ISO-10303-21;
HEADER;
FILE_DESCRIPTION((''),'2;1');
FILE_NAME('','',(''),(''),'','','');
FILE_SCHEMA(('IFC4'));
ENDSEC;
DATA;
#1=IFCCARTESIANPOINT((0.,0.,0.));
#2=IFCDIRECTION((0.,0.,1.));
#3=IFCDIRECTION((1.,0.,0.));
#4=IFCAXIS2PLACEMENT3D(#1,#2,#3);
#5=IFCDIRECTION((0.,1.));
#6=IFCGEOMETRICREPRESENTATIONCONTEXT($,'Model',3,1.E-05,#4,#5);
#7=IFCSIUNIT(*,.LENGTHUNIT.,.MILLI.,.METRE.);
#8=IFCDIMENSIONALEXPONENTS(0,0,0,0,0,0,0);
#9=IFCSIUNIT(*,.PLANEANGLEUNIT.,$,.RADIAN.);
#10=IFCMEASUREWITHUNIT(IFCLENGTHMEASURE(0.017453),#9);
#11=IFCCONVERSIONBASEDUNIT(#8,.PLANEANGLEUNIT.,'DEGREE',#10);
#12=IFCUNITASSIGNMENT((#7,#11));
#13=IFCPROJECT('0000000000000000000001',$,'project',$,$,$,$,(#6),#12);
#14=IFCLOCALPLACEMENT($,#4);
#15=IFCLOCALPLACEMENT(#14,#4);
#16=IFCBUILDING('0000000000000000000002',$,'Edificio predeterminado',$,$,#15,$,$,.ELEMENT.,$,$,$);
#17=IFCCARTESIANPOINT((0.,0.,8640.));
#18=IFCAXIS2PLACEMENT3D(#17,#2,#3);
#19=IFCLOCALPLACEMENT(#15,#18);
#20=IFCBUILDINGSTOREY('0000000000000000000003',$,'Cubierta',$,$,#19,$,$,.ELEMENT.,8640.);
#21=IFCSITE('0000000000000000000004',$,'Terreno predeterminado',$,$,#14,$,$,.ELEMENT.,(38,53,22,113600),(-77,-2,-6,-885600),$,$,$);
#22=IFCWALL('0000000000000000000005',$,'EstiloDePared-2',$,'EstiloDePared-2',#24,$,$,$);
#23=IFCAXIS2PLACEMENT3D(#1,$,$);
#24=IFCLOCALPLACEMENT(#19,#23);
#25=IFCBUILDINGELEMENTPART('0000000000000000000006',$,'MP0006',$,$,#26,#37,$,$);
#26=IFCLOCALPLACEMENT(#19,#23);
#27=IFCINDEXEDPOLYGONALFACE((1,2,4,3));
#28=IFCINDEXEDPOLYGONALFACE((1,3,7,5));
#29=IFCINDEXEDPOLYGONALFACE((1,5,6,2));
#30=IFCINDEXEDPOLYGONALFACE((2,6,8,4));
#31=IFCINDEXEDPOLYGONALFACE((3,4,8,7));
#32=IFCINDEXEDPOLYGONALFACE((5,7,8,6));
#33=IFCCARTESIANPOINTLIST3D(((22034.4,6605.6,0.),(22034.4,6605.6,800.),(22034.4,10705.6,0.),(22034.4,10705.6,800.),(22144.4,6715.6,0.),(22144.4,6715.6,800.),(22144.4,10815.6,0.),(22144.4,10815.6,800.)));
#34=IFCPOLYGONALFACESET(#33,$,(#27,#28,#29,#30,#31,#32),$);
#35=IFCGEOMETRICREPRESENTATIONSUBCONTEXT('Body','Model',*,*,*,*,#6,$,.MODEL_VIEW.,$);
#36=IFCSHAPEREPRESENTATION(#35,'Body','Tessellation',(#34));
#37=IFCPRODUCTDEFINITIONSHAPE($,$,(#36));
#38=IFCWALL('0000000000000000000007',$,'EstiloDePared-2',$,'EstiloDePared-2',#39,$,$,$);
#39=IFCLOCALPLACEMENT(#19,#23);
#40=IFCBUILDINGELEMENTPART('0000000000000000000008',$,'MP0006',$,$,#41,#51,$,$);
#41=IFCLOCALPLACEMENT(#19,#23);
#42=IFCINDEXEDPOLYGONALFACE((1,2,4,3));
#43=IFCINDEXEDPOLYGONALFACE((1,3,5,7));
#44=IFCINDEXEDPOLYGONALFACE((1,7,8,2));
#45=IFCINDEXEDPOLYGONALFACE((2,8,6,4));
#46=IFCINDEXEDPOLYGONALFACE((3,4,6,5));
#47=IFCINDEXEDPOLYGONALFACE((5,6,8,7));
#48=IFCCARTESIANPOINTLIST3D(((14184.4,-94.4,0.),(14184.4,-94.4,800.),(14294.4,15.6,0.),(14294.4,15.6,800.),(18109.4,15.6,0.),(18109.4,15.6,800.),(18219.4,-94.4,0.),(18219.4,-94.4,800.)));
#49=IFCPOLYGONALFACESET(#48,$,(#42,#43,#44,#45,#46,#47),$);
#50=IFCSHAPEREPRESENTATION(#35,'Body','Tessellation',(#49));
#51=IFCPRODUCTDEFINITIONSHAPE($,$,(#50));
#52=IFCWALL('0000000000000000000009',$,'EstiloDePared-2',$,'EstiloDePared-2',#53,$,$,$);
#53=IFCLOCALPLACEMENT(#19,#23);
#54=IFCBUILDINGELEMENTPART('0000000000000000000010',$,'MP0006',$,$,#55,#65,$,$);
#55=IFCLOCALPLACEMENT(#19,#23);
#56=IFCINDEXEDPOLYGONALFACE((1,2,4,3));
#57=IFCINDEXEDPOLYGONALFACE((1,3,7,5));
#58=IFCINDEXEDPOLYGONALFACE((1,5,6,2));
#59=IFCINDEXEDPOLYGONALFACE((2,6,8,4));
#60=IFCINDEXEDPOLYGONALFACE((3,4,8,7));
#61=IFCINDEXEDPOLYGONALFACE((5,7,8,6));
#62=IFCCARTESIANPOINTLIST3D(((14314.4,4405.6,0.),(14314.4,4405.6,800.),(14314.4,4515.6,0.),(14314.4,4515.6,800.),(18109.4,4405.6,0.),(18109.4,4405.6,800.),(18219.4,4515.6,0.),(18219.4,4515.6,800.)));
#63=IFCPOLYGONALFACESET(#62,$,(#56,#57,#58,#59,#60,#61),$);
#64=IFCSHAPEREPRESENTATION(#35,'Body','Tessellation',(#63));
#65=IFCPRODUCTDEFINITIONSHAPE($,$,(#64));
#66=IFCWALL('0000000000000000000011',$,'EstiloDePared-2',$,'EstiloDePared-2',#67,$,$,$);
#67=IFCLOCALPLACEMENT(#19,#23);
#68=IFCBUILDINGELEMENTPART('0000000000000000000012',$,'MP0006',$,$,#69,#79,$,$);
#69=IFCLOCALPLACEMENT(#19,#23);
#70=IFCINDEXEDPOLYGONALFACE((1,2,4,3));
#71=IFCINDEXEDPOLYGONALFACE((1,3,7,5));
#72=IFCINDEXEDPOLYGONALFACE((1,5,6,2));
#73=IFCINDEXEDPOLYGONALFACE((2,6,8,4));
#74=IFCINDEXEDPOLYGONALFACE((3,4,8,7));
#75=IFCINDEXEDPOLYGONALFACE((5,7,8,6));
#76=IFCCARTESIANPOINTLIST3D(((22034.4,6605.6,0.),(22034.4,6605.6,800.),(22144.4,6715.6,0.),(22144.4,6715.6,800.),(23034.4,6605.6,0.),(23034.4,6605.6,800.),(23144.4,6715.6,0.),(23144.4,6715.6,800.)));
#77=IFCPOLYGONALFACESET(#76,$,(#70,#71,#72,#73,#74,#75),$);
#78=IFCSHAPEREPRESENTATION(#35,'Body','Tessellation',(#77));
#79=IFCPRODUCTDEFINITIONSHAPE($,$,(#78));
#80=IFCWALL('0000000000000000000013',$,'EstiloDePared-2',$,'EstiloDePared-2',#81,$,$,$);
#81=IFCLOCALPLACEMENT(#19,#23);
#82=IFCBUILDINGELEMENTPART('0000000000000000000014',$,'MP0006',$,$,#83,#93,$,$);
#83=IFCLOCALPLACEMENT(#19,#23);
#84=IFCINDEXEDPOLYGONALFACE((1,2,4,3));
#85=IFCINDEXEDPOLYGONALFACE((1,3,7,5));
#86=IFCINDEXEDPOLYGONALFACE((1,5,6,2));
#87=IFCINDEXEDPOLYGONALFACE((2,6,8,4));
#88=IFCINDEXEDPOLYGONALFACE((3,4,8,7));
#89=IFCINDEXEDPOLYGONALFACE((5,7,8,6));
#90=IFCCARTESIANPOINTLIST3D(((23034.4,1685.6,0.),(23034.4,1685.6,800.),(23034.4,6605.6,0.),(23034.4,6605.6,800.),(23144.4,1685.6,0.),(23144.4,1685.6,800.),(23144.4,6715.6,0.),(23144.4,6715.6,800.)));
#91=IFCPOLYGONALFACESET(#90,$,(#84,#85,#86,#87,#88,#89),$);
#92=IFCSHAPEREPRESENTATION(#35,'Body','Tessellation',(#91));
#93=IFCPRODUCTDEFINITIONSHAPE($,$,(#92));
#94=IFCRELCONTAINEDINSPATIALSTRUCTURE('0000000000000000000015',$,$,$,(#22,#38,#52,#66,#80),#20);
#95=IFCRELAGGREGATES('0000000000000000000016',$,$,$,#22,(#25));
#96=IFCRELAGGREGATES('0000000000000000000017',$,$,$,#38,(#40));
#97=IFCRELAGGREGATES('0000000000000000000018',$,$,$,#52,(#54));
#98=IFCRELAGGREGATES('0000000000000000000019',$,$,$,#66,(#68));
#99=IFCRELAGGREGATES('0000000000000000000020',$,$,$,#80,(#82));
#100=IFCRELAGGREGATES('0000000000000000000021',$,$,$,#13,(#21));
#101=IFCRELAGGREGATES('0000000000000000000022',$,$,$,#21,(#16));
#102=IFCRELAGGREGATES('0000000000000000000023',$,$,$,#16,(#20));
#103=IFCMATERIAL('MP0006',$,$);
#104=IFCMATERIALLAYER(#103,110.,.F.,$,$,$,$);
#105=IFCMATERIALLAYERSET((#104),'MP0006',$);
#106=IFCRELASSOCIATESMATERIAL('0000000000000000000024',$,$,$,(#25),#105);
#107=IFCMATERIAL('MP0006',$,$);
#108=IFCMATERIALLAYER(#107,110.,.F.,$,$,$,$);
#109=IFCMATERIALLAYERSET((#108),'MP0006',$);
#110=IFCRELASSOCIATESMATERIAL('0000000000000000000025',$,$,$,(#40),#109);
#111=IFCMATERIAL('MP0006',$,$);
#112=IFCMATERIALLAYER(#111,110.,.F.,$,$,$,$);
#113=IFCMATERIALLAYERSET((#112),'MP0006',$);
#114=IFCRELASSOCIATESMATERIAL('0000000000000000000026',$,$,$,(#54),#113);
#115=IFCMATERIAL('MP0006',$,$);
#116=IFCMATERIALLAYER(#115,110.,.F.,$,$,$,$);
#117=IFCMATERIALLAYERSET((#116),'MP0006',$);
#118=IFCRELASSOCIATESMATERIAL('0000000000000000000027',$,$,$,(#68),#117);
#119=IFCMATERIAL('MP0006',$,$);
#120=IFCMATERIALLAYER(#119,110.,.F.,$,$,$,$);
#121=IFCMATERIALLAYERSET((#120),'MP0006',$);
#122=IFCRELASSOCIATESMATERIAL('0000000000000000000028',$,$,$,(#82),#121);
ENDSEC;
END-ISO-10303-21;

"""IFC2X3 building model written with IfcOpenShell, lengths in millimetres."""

from ifc_helpers import new_model, entity, si_unit, converted_unit, direction, frame, origin_with_axes, place, context, subcontext, project, spatial, polyline, outline, extrude, material, layer, layer_set, layer_usage, element, aggregate, save


model = new_model("IFC2X3")

# Units and contexts
model_context = context("Model", 3, precision=1e-05, world=origin_with_axes(), true_north=direction((0.0, 1.0)))
body_context = subcontext(model_context, "Body", "Model", "MODEL_VIEW")
ifc_project = project(units=[si_unit("LENGTHUNIT", "METRE", prefix="MILLI"), converted_unit("PLANEANGLEUNIT", "DEGREE", entity("IfcLengthMeasure", 0.017453), si_unit("PLANEANGLEUNIT", "RADIAN"), dimensions=[0, 0, 0, 0, 0, 0, 0])], contexts=[model_context])

# Site, building, storey
site_placement = place(None, origin_with_axes())
site = spatial("IfcSite", under=ifc_project, at=site_placement, Name="Terreno predeterminado", CompositionType="ELEMENT", RefLatitude=(38, 53, 22, 113600), RefLongitude=(-77, -2, -6, -885600))
building_placement = place(site_placement, origin_with_axes())
building = spatial("IfcBuilding", under=site, at=building_placement, Name="Edificio predeterminado", CompositionType="ELEMENT")
storey_placement = place(building_placement, frame((0.0, 0.0, 8640.0), z_axis=(0.0, 0.0, 1.0), x_axis=(1.0, 0.0, 0.0)))
storey = spatial("IfcBuildingStorey", under=building, at=storey_placement, Name="Cubierta", CompositionType="ELEMENT", Elevation=8640.0)

# Wall, building element part
wall_1_placement = place(storey_placement, frame((22089.4, 10760.6, 0.0), z_axis=(0.0, 0.0, 1.0), x_axis=(0.0, -1.0, 0.0)))
wall_1 = element("IfcWall", 1, at=wall_1_placement, inside=storey, Name="EstiloDePared-2", ObjectType="EstiloDePared-2")
ifc_material_1 = material(Name="MP0006")
ifc_layer_1 = layer(ifc_material_1, 110.0, ventilated=False)
ifc_layer_set_1 = layer_set([ifc_layer_1], Name="MP0006")
ifc_layer_usage_1 = layer_usage(ifc_layer_set_1, "AXIS2", "NEGATIVE", -55.0)
building_element_part_1_placement = place(wall_1_placement, origin_with_axes())
building_element_part_1 = element("IfcBuildingElementPart", 2, at=building_element_part_1_placement, material=ifc_layer_usage_1, Name="MP0006", context=body_context, shape_type="SweptSolid", body=[
    extrude(outline(polyline([(4045.0, 55.0), (4155.0, -55.0), (55.0, -55.0), (-55.0, 55.0), (4045.0, 55.0)])), origin_with_axes(), (0.0, 0.0, 1.0), 800.0),
])
aggregate(wall_1, [building_element_part_1])

# Walls, building element parts
wall_2_placement = place(storey_placement, frame((18164.4, -39.4, 0.0), z_axis=(0.0, 0.0, 1.0), x_axis=(-1.0, 0.0, 0.0)))
wall_2 = element("IfcWall", 3, at=wall_2_placement, inside=storey, Name="EstiloDePared-2", ObjectType="EstiloDePared-2")
ifc_material_2 = material(Name="MP0006")
ifc_layer_2 = layer(ifc_material_2, 110.0, ventilated=False)
ifc_layer_set_2 = layer_set([ifc_layer_2], Name="MP0006")
ifc_layer_usage_2 = layer_usage(ifc_layer_set_2, "AXIS2", "NEGATIVE", -55.0)
building_element_part_2_placement = place(wall_2_placement, origin_with_axes())
building_element_part_2 = element("IfcBuildingElementPart", 4, at=building_element_part_2_placement, material=ifc_layer_usage_2, Name="MP0006", context=body_context, shape_type="SweptSolid", body=[
    extrude(outline(polyline([(3980.0, 55.0), (3870.0, -55.0), (55.0, -55.0), (-55.0, 55.0), (3980.0, 55.0)])), origin_with_axes(), (0.0, 0.0, 1.0), 800.0),
])
aggregate(wall_2, [building_element_part_2])
wall_3_placement = place(storey_placement, frame((18164.4, 4460.6, 0.0), z_axis=(0.0, 0.0, 1.0), x_axis=(-1.0, 0.0, 0.0)))
wall_3 = element("IfcWall", 5, at=wall_3_placement, inside=storey, Name="EstiloDePared-2", ObjectType="EstiloDePared-2")
ifc_material_3 = material(Name="MP0006")
ifc_layer_3 = layer(ifc_material_3, 110.0, ventilated=False)
ifc_layer_set_3 = layer_set([ifc_layer_3], Name="MP0006")
ifc_layer_usage_3 = layer_usage(ifc_layer_set_3, "AXIS2", "NEGATIVE", -55.0)
building_element_part_3_placement = place(wall_3_placement, origin_with_axes())
building_element_part_3 = element("IfcBuildingElementPart", 6, at=building_element_part_3_placement, material=ifc_layer_usage_3, Name="MP0006", context=body_context, shape_type="SweptSolid", body=[
    extrude(outline(polyline([(3850.0, 55.0), (3850.0, -55.0), (-55.0, -55.0), (55.0, 55.0), (3850.0, 55.0)])), origin_with_axes(), (0.0, 0.0, 1.0), 800.0),
])
aggregate(wall_3, [building_element_part_3])
wall_4_placement = place(storey_placement, frame((22089.4, 6660.6, 0.0), z_axis=(0.0, 0.0, 1.0), x_axis=(1.0, 0.0, 0.0)))
wall_4 = element("IfcWall", 7, at=wall_4_placement, inside=storey, Name="EstiloDePared-2", ObjectType="EstiloDePared-2")
ifc_material_4 = material(Name="MP0006")
ifc_layer_4 = layer(ifc_material_4, 110.0, ventilated=False)
ifc_layer_set_4 = layer_set([ifc_layer_4], Name="MP0006")
ifc_layer_usage_4 = layer_usage(ifc_layer_set_4, "AXIS2", "NEGATIVE", -55.0)
building_element_part_4_placement = place(wall_4_placement, origin_with_axes())
building_element_part_4 = element("IfcBuildingElementPart", 8, at=building_element_part_4_placement, material=ifc_layer_usage_4, Name="MP0006", context=body_context, shape_type="SweptSolid", body=[
    extrude(outline(polyline([(1055.0, 55.0), (945.0, -55.0), (-55.0, -55.0), (55.0, 55.0), (1055.0, 55.0)])), origin_with_axes(), (0.0, 0.0, 1.0), 800.0),
])
aggregate(wall_4, [building_element_part_4])
wall_5_placement = place(storey_placement, frame((23089.4, 6660.6, 0.0), z_axis=(0.0, 0.0, 1.0), x_axis=(0.0, -1.0, 0.0)))
wall_5 = element("IfcWall", 9, at=wall_5_placement, inside=storey, Name="EstiloDePared-2", ObjectType="EstiloDePared-2")
ifc_material_5 = material(Name="MP0006")
ifc_layer_5 = layer(ifc_material_5, 110.0, ventilated=False)
ifc_layer_set_5 = layer_set([ifc_layer_5], Name="MP0006")
ifc_layer_usage_5 = layer_usage(ifc_layer_set_5, "AXIS2", "NEGATIVE", -55.0)
building_element_part_5_placement = place(wall_5_placement, origin_with_axes())
building_element_part_5 = element("IfcBuildingElementPart", 10, at=building_element_part_5_placement, material=ifc_layer_usage_5, Name="MP0006", context=body_context, shape_type="SweptSolid", body=[
    extrude(outline(polyline([(4975.0, 55.0), (4975.0, -55.0), (55.0, -55.0), (-55.0, 55.0), (4975.0, 55.0)])), origin_with_axes(), (0.0, 0.0, 1.0), 800.0),
])
aggregate(wall_5, [building_element_part_5])

save(model, "model.ifc")
